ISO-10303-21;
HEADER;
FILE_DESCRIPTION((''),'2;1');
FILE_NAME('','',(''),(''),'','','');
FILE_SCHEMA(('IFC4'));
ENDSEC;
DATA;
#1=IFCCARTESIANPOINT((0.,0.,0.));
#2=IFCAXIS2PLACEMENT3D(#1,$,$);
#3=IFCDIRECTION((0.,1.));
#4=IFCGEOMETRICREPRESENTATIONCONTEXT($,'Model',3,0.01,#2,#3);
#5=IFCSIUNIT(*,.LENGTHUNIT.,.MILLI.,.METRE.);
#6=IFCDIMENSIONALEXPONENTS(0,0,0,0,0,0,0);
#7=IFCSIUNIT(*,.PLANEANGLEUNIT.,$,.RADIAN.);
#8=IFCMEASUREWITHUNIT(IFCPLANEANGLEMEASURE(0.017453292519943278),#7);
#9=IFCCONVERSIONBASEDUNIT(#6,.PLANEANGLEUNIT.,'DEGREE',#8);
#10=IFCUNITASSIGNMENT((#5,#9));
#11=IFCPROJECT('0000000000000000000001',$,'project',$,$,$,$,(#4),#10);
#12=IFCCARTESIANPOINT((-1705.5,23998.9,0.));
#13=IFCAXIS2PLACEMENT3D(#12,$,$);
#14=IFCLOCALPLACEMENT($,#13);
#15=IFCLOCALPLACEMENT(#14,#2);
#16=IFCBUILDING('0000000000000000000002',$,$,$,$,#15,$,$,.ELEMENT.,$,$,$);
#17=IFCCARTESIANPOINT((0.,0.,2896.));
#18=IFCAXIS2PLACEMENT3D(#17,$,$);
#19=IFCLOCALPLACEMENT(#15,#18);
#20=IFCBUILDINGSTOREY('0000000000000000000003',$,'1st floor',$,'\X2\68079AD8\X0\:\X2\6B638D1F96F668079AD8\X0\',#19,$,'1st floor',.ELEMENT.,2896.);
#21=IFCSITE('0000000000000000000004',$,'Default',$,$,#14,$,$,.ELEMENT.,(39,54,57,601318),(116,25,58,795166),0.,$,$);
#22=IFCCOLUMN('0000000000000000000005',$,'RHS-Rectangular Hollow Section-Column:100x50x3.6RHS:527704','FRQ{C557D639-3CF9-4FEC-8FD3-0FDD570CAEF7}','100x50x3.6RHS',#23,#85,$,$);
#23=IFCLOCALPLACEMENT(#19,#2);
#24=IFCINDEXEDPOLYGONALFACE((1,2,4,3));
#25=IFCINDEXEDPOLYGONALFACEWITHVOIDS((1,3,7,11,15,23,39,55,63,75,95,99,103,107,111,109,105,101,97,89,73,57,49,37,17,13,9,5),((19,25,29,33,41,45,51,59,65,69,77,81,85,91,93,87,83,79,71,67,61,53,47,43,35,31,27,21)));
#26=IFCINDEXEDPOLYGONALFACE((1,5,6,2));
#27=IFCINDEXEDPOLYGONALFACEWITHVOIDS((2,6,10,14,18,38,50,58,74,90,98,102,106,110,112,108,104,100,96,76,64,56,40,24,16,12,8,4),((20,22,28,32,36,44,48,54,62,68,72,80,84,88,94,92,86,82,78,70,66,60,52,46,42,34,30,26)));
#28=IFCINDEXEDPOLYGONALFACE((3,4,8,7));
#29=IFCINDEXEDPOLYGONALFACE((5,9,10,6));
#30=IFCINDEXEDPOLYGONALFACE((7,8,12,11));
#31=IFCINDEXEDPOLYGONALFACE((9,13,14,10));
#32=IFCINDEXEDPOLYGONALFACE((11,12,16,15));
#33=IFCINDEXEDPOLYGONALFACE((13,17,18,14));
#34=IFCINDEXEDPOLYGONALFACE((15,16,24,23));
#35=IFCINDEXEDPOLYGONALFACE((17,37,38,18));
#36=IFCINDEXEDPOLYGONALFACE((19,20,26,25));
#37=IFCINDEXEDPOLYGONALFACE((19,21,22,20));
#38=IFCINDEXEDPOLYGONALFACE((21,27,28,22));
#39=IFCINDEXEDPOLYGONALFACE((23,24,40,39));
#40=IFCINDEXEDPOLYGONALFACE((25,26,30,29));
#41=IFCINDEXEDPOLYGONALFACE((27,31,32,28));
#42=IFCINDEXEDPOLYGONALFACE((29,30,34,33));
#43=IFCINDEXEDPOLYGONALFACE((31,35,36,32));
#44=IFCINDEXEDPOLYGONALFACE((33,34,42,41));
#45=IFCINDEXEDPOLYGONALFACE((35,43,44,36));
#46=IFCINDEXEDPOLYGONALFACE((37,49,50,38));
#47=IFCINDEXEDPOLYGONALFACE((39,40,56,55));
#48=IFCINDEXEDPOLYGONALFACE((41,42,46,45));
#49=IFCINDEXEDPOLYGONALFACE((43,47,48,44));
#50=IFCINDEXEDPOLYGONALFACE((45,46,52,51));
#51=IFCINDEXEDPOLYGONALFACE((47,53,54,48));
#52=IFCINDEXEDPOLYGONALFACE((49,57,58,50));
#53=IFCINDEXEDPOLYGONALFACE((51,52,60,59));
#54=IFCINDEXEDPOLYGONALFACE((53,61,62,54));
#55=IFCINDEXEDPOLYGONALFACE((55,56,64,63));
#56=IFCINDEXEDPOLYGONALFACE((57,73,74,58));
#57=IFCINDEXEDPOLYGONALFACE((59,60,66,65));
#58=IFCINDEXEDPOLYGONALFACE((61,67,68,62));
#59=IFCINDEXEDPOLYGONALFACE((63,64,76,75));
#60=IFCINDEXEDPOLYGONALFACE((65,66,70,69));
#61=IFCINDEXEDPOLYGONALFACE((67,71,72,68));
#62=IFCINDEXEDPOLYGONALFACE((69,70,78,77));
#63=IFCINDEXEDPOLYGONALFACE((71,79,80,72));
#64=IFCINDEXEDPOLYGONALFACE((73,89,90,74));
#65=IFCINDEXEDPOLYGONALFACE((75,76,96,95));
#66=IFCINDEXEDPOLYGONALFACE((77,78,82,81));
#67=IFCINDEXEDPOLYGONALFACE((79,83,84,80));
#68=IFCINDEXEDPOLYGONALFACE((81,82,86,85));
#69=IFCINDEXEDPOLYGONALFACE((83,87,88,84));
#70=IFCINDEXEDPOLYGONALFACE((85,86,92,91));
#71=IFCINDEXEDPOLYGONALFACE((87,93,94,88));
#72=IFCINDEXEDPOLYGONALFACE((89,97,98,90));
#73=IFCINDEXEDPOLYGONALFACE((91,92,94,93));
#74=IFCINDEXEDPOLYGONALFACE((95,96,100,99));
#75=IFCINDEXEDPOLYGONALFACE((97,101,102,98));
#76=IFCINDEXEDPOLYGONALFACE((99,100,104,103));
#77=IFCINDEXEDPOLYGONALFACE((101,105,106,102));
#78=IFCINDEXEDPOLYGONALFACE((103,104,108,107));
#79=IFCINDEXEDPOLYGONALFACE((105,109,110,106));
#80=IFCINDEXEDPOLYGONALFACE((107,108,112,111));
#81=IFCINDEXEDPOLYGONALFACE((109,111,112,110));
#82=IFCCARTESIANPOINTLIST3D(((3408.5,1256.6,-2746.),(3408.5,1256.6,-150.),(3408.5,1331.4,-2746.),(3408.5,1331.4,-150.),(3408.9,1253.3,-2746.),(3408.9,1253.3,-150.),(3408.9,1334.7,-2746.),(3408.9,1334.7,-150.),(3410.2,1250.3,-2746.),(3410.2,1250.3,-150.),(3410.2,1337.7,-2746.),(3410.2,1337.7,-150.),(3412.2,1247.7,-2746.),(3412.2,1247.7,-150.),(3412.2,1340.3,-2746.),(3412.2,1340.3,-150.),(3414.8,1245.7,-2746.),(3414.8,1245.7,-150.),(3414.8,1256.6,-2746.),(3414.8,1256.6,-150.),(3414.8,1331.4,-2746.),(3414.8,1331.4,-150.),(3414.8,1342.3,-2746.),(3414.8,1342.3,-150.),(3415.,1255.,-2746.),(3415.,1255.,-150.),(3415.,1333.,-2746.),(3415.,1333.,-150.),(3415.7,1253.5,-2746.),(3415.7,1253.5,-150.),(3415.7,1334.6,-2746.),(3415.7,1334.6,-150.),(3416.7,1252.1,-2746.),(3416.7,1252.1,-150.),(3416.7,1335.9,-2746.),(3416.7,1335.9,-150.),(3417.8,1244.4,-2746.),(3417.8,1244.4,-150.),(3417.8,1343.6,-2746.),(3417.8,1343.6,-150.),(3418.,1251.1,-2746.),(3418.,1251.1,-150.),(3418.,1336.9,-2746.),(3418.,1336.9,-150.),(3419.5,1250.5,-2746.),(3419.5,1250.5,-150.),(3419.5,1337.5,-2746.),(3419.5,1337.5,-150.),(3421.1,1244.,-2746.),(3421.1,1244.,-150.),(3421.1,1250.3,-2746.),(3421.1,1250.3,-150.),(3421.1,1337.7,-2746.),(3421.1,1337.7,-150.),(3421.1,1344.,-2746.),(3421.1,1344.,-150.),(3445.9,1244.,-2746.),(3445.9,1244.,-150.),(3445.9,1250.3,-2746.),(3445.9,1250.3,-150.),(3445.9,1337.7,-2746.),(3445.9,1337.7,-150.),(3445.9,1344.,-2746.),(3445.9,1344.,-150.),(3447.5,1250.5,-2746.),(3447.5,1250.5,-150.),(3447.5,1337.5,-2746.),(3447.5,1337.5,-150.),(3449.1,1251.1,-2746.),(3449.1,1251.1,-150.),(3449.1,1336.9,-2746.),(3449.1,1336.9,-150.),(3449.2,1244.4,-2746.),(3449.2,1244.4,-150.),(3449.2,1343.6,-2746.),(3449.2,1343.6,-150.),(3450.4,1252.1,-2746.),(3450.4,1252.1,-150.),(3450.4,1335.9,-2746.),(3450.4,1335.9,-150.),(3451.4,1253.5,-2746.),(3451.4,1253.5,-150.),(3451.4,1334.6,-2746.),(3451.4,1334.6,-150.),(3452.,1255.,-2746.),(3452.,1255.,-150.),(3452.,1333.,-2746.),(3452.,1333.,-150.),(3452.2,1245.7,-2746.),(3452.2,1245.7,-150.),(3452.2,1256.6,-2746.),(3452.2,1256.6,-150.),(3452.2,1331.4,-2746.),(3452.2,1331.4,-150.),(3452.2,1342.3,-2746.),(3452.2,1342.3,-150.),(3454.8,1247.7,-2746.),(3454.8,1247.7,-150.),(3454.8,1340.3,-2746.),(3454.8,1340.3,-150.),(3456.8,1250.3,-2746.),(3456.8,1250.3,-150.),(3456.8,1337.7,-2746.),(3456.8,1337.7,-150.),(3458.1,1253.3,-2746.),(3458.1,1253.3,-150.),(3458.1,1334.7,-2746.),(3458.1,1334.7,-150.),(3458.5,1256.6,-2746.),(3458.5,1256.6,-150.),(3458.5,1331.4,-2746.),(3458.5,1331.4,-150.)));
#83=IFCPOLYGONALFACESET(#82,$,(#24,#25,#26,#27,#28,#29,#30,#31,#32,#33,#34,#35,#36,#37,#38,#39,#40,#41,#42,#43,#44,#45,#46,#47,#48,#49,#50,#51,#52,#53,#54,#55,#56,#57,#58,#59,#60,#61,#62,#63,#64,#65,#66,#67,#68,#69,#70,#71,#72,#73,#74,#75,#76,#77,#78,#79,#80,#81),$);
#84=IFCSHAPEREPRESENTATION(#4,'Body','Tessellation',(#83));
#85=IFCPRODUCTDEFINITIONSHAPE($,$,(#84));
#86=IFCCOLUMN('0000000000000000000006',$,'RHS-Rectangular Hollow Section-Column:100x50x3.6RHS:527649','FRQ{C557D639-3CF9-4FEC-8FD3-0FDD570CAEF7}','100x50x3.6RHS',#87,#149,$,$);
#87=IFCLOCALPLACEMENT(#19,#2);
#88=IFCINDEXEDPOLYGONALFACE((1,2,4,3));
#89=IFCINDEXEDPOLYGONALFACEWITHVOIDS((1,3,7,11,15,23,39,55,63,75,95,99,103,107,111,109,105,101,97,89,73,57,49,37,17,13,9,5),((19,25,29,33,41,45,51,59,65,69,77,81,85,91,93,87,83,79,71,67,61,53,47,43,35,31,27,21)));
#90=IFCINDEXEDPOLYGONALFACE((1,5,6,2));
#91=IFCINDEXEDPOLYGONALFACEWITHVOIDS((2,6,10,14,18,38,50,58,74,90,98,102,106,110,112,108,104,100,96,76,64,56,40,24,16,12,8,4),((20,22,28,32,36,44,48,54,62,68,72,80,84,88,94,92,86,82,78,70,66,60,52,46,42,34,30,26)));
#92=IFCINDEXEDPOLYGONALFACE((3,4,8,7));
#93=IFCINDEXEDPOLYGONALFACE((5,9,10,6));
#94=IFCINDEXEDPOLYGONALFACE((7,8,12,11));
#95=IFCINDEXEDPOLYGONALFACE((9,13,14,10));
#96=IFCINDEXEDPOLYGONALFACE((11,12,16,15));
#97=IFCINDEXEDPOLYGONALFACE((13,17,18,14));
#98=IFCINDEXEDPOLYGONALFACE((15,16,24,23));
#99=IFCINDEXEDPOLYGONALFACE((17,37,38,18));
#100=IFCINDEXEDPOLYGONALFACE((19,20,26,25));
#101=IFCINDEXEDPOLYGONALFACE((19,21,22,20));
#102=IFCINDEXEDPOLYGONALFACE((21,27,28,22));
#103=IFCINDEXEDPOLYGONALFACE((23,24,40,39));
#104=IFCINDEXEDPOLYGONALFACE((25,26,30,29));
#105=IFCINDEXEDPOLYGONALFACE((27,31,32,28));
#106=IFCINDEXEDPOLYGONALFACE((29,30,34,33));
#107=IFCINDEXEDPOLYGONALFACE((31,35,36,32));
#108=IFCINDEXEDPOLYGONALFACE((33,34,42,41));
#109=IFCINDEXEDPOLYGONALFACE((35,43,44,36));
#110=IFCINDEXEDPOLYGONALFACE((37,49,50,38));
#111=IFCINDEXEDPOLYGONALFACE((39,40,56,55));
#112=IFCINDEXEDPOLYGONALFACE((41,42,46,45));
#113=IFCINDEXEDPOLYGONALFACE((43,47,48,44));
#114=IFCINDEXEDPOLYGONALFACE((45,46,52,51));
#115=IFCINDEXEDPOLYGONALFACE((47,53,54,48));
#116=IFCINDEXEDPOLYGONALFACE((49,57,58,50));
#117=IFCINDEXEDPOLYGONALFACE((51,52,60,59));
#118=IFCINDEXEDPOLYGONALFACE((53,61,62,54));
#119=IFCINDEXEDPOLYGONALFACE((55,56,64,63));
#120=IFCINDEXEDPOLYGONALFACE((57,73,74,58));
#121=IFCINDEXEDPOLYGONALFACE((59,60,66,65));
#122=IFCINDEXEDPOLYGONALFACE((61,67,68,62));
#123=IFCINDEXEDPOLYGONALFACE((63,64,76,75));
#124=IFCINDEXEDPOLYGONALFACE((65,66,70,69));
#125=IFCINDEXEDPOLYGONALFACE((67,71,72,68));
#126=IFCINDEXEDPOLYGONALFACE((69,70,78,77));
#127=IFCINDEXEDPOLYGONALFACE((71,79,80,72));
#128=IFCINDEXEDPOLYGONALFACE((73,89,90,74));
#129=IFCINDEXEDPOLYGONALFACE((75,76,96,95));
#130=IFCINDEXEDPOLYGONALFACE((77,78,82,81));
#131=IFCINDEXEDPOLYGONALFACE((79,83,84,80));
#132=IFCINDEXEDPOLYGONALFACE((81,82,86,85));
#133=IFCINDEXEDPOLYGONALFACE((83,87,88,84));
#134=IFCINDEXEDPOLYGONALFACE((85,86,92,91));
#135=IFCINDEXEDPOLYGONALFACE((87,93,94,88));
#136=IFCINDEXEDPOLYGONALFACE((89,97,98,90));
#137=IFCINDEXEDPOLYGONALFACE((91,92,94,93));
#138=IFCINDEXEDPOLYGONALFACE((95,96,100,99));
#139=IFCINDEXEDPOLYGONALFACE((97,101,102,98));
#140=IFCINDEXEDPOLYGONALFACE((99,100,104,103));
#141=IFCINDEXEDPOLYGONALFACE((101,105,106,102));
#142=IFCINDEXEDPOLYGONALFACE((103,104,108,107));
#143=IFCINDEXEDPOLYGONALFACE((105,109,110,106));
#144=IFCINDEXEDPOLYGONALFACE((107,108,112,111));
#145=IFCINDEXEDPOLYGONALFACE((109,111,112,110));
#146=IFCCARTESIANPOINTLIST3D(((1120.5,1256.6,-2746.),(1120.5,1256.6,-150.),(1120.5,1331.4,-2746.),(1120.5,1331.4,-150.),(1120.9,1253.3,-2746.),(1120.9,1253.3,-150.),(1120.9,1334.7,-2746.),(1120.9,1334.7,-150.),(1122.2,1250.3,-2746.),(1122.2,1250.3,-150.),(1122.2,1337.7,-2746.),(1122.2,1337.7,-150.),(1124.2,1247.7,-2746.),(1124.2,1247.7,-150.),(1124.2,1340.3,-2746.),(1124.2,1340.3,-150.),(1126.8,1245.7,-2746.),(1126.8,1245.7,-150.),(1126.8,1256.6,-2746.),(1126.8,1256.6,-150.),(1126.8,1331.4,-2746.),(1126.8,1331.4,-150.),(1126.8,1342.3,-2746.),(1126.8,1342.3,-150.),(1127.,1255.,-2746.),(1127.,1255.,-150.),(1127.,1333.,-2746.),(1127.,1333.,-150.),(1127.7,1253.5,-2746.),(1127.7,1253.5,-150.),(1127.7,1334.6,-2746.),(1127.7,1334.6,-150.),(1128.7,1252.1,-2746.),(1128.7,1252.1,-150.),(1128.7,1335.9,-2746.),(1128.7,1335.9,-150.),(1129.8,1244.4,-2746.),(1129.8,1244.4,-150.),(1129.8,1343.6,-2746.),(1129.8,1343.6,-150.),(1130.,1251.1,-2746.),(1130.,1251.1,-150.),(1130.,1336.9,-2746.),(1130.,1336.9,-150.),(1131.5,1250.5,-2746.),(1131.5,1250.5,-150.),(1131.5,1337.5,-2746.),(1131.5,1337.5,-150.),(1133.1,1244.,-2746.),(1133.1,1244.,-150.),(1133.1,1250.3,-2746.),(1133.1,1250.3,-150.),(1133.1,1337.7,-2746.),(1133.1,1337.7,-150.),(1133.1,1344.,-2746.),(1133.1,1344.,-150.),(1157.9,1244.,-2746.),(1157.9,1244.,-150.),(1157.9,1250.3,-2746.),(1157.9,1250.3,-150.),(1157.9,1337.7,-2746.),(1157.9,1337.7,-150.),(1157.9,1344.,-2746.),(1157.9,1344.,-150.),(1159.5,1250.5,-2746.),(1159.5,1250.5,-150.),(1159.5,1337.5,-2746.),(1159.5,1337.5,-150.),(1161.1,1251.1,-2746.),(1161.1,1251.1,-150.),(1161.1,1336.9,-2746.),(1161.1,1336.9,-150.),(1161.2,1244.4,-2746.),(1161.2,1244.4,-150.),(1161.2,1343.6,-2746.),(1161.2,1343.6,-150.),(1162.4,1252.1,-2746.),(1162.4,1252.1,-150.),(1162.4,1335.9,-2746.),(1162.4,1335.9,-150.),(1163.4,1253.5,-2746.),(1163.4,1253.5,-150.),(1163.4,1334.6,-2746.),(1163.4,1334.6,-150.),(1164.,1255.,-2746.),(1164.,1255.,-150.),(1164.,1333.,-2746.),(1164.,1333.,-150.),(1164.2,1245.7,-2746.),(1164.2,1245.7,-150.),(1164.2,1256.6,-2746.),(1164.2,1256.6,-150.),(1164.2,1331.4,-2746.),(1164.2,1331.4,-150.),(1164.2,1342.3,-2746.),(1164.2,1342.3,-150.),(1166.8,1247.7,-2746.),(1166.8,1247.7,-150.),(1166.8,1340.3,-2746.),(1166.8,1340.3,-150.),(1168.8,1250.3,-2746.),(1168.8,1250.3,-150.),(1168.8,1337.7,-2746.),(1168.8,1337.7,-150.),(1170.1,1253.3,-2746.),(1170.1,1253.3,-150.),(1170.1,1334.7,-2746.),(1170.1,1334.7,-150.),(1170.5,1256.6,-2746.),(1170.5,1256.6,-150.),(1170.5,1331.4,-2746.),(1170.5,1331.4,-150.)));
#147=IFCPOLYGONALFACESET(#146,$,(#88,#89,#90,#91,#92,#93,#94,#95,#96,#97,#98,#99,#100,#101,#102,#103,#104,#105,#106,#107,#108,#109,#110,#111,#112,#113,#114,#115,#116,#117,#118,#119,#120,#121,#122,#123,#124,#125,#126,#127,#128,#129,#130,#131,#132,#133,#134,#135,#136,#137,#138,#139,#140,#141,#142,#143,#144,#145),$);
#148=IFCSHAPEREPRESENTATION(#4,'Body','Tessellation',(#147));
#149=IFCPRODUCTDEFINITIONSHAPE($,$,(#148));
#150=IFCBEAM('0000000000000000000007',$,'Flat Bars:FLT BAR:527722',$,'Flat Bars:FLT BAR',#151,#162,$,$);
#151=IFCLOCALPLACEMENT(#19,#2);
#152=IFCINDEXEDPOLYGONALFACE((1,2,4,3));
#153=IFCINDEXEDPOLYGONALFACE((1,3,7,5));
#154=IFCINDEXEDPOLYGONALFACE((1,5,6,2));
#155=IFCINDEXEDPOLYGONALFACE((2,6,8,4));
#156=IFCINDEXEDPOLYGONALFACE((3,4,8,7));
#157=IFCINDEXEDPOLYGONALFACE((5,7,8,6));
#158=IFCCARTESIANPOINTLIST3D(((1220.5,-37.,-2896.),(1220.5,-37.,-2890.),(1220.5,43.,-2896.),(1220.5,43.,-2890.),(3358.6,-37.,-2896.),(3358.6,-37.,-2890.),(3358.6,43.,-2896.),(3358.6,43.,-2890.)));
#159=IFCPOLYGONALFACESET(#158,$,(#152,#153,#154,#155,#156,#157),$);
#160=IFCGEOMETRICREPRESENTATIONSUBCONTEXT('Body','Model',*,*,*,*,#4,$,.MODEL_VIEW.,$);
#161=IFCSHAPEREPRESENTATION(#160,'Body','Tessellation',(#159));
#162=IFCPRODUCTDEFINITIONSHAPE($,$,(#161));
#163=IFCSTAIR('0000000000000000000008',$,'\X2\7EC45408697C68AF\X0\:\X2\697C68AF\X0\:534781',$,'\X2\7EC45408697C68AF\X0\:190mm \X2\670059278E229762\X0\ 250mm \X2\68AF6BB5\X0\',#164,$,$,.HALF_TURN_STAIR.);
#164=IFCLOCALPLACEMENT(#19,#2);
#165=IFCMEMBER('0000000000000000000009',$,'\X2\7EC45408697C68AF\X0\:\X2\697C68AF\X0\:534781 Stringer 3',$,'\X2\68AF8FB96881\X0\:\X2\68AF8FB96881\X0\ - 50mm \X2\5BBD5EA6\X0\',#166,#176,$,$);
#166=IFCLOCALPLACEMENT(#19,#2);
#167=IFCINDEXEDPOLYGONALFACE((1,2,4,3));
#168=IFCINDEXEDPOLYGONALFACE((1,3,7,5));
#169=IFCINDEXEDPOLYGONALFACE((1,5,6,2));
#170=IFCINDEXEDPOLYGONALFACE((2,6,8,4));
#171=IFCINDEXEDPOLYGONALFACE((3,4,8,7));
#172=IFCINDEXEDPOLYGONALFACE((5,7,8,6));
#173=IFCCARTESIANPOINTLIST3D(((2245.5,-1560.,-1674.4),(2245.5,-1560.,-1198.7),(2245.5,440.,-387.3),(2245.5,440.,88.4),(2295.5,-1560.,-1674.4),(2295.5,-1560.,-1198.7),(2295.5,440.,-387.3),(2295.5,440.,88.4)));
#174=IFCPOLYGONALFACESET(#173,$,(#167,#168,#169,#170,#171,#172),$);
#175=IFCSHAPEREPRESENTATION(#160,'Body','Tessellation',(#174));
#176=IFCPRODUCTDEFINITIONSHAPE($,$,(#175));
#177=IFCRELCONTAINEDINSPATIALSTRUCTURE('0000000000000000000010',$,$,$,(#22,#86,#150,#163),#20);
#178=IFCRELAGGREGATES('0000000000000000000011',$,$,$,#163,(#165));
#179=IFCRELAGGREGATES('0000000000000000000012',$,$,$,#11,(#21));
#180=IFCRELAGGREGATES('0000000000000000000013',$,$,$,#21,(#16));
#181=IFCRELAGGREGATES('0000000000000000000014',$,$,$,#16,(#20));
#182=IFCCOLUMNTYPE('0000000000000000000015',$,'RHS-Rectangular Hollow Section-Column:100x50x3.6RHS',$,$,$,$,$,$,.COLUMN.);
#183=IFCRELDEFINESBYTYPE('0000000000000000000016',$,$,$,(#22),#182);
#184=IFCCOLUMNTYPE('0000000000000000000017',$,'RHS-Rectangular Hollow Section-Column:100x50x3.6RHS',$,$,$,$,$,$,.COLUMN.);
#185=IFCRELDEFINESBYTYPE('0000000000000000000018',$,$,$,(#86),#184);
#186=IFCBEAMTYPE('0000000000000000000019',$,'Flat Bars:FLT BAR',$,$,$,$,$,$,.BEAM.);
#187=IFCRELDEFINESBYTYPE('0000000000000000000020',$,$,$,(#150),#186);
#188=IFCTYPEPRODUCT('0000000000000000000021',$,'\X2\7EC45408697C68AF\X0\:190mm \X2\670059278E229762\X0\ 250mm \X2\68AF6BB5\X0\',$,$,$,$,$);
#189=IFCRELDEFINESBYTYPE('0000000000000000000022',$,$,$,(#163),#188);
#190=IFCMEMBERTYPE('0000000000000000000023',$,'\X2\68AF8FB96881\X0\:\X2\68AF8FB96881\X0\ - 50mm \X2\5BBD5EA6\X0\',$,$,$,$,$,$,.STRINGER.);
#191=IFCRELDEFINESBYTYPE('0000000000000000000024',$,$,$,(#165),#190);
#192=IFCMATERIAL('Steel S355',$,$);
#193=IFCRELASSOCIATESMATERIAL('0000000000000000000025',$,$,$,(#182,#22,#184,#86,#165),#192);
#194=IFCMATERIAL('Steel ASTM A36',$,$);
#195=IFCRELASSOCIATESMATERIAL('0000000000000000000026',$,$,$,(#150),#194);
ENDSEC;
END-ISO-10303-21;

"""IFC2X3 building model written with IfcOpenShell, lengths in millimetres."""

from ifc_helpers import new_model, entity, si_unit, converted_unit, point, direction, frame, frame_2d, origin, origin_2d, origin_2d_with_axis, place, context, subcontext, project, spatial, polyline, circle_curve, line_curve, trimmed, segment, composite_curve, rectangle, hollow_rectangle, outline, extrude, clip, halfspace, material, type_object, element, aggregate, save


model = new_model("IFC2X3")

# Units and contexts
model_context = context("Model", 3, precision=0.01, world=origin(), true_north=direction((0.0, 1.0)))
body_context = subcontext(model_context, "Body", "Model", "MODEL_VIEW")
ifc_project = project(units=[si_unit("LENGTHUNIT", "METRE", prefix="MILLI"), converted_unit("PLANEANGLEUNIT", "DEGREE", entity("IfcPlaneAngleMeasure", 0.017453292519943278), si_unit("PLANEANGLEUNIT", "RADIAN"), dimensions=[0, 0, 0, 0, 0, 0, 0])], contexts=[model_context])

# Site, building, storey
site_placement = place(None, frame((-1705.5, 23998.9, 0.0)))
site = spatial("IfcSite", under=ifc_project, at=site_placement, Name="Default", CompositionType="ELEMENT", RefLatitude=(39, 54, 57, 601318), RefLongitude=(116, 25, 58, 795166), RefElevation=0.0)
building_placement = place(site_placement, origin())
building = spatial("IfcBuilding", under=site, at=building_placement, CompositionType="ELEMENT")
storey_placement = place(building_placement, frame((0.0, 0.0, 2896.0)))
storey = spatial("IfcBuildingStorey", under=building, at=storey_placement, Name="1st floor", ObjectType="标高:正负零标高", LongName="1st floor", CompositionType="ELEMENT", Elevation=2896.0)

# Column
ifc_material_1 = material(Name="Steel S355")
column_type_1 = type_object("IfcColumnType", Name="RHS-Rectangular Hollow Section-Column:100x50x3.6RHS", PredefinedType="COLUMN", material=ifc_material_1)
column_1_placement = place(storey_placement, frame((3433.5, 1294.0, -150.0), z_axis=(0.0, 0.0, 1.0), x_axis=(-1.0, 0.0, 0.0)))
element("IfcColumn", 1, at=column_1_placement, inside=storey, type_object=column_type_1, material=ifc_material_1, Name="RHS-Rectangular Hollow Section-Column:100x50x3.6RHS:527704", Description="FRQ{C557D639-3CF9-4FEC-8FD3-0FDD570CAEF7}", ObjectType="100x50x3.6RHS", context=model_context, shape_type="Clipping", body=[
    clip(extrude(hollow_rectangle(XDim=50.0, YDim=100.0, WallThickness=6.3, InnerFilletRadius=6.3, OuterFilletRadius=12.6, at=origin_2d()), origin(), (0.0, 0.0, -1.0), 2651.9), halfspace(frame((3433.5, 1294.0, -2596.0), z_axis=(0.0, 0.0, 1.0), x_axis=(-1.0, 0.0, 0.0)), True)),
])

# Column, opening
column_type_2 = type_object("IfcColumnType", Name="RHS-Rectangular Hollow Section-Column:100x50x3.6RHS", PredefinedType="COLUMN", material=ifc_material_1)
column_2_placement = place(storey_placement, frame((1145.5, 1294.0, -19.1)))
column_2 = element("IfcColumn", 2, at=column_2_placement, inside=storey, type_object=column_type_2, material=ifc_material_1, Name="RHS-Rectangular Hollow Section-Column:100x50x3.6RHS:527649", Description="FRQ{C557D639-3CF9-4FEC-8FD3-0FDD570CAEF7}", ObjectType="100x50x3.6RHS", context=model_context, shape_type="Clipping", body=[
    clip(clip(extrude(hollow_rectangle(XDim=50.0, YDim=100.0, WallThickness=6.3, InnerFilletRadius=6.3, OuterFilletRadius=12.6, at=origin_2d()), origin(), (0.0, 0.0, -1.0), 2782.8), halfspace(frame((-1145.5, -1294.0, -2726.9), z_axis=(0.0, 0.0, 1.0), x_axis=(1.0, 0.0, 0.0)), True)), halfspace(frame((-1145.5, -1294.0, -55.9), z_axis=(0.0, 0.0, -1.0), x_axis=(-1.0, 0.0, 0.0)), True)),
])
opening_1_placement = place(column_2_placement, frame((0.0, -150.1, -130.9), z_axis=(0.0, 1.0, 0.0), x_axis=(-1.0, 0.0, 0.0)))
element("IfcOpeningElement", 3, at=opening_1_placement, cuts=column_2, ObjectType="Opening", context=model_context, shape_type="SweptSolid", body=[
    extrude(outline(composite_curve([segment(trimmed(circle_curve(frame_2d((43.0, 32.0), x_axis=(1.0, 0.0)), 32.0), [point((43.0, 0.0))], [point((75.0, 32.0))], True, "CARTESIAN"), True, "CONTINUOUS"), segment(trimmed(line_curve((75.0, 32.0), (0.0, 1.0), 86.0), [point((75.0, 32.0))], [point((75.0, 118.0))], True, "CARTESIAN"), True, "CONTINUOUS"), segment(trimmed(circle_curve(frame_2d((43.0, 118.0), x_axis=(1.0, 0.0)), 32.0), [point((75.0, 118.0))], [point((43.0, 150.0))], True, "CARTESIAN"), True, "CONTINUOUS"), segment(trimmed(line_curve((43.0, 150.0), (-1.0, 0.0), 86.0), [point((43.0, 150.0))], [point((-43.0, 150.0))], True, "CARTESIAN"), True, "CONTINUOUS"), segment(trimmed(circle_curve(frame_2d((-43.0, 118.0), x_axis=(1.0, 0.0)), 32.0), [point((-43.0, 150.0))], [point((-75.0, 118.0))], True, "CARTESIAN"), True, "CONTINUOUS"), segment(trimmed(line_curve((-75.0, 118.0), (0.0, -1.0), 86.0), [point((-75.0, 118.0))], [point((-75.0, 32.0))], True, "CARTESIAN"), True, "CONTINUOUS"), segment(trimmed(circle_curve(frame_2d((-43.0, 32.0), x_axis=(1.0, 0.0)), 32.0), [point((-75.0, 32.0))], [point((-43.0, 0.0))], True, "CARTESIAN"), True, "CONTINUOUS"), segment(trimmed(line_curve((-43.0, 0.0), (1.0, 0.0), 86.0), [point((-43.0, 0.0))], [point((43.0, 0.0))], True, "CARTESIAN"), True, "CONTINUOUS")], self_intersect="UNKNOWN")), origin(), (0.0, 0.0, 1.0), 300.2),
])

# Beam
ifc_material_2 = material(Name="Steel ASTM A36")
beam_type_1 = type_object("IfcBeamType", Name="Flat Bars:FLT BAR", PredefinedType="BEAM")
beam_1_placement = place(storey_placement, frame((1220.5, 3.0, -2890.0)))
element("IfcBeam", 4, at=beam_1_placement, inside=storey, type_object=beam_type_1, material=ifc_material_2, Name="Flat Bars:FLT BAR:527722", ObjectType="Flat Bars:FLT BAR", context=body_context, shape_type="SweptSolid", body=[
    extrude(rectangle(XDim=6.0, YDim=80.0, at=origin_2d_with_axis()), frame((0.0, 0.0, -3.0), z_axis=(1.0, 0.0, 0.0), x_axis=(0.0, 0.0, -1.0)), (0.0, 0.0, 1.0), 2138.1),
])

# Stair, member
type_product = type_object("IfcTypeProduct", Name="组合楼梯:190mm 最大踢面 250mm 梯段")
stair_placement = place(storey_placement, origin())
stair = element("IfcStair", 5, at=stair_placement, inside=storey, type_object=type_product, Name="组合楼梯:楼梯:534781", ObjectType="组合楼梯:190mm 最大踢面 250mm 梯段", ShapeType="HALF_TURN_STAIR")
member_type_1 = type_object("IfcMemberType", Name="梯边梁:梯边梁 - 50mm 宽度", PredefinedType="STRINGER")
member_1_placement = place(stair_placement, origin())
member_1 = element("IfcMember", 6, at=member_1_placement, type_object=member_type_1, material=ifc_material_1, Name="组合楼梯:楼梯:534781 Stringer 3", ObjectType="梯边梁:梯边梁 - 50mm 宽度", context=body_context, shape_type="SweptSolid", body=[
    extrude(outline(polyline([(-1317.9, -200.0), (1060.5, -200.0), (1317.9, 200.0), (-1060.5, 200.0), (-1317.9, -200.0)])), frame((2245.5, -560.0, -793.0), z_axis=(1.0, 0.0, 0.0), x_axis=(0.0, 0.840911, 0.541173)), (0.0, 0.0, 1.0), 50.0),
])

aggregate(stair, [member_1])

save(model, "model.ifc")
